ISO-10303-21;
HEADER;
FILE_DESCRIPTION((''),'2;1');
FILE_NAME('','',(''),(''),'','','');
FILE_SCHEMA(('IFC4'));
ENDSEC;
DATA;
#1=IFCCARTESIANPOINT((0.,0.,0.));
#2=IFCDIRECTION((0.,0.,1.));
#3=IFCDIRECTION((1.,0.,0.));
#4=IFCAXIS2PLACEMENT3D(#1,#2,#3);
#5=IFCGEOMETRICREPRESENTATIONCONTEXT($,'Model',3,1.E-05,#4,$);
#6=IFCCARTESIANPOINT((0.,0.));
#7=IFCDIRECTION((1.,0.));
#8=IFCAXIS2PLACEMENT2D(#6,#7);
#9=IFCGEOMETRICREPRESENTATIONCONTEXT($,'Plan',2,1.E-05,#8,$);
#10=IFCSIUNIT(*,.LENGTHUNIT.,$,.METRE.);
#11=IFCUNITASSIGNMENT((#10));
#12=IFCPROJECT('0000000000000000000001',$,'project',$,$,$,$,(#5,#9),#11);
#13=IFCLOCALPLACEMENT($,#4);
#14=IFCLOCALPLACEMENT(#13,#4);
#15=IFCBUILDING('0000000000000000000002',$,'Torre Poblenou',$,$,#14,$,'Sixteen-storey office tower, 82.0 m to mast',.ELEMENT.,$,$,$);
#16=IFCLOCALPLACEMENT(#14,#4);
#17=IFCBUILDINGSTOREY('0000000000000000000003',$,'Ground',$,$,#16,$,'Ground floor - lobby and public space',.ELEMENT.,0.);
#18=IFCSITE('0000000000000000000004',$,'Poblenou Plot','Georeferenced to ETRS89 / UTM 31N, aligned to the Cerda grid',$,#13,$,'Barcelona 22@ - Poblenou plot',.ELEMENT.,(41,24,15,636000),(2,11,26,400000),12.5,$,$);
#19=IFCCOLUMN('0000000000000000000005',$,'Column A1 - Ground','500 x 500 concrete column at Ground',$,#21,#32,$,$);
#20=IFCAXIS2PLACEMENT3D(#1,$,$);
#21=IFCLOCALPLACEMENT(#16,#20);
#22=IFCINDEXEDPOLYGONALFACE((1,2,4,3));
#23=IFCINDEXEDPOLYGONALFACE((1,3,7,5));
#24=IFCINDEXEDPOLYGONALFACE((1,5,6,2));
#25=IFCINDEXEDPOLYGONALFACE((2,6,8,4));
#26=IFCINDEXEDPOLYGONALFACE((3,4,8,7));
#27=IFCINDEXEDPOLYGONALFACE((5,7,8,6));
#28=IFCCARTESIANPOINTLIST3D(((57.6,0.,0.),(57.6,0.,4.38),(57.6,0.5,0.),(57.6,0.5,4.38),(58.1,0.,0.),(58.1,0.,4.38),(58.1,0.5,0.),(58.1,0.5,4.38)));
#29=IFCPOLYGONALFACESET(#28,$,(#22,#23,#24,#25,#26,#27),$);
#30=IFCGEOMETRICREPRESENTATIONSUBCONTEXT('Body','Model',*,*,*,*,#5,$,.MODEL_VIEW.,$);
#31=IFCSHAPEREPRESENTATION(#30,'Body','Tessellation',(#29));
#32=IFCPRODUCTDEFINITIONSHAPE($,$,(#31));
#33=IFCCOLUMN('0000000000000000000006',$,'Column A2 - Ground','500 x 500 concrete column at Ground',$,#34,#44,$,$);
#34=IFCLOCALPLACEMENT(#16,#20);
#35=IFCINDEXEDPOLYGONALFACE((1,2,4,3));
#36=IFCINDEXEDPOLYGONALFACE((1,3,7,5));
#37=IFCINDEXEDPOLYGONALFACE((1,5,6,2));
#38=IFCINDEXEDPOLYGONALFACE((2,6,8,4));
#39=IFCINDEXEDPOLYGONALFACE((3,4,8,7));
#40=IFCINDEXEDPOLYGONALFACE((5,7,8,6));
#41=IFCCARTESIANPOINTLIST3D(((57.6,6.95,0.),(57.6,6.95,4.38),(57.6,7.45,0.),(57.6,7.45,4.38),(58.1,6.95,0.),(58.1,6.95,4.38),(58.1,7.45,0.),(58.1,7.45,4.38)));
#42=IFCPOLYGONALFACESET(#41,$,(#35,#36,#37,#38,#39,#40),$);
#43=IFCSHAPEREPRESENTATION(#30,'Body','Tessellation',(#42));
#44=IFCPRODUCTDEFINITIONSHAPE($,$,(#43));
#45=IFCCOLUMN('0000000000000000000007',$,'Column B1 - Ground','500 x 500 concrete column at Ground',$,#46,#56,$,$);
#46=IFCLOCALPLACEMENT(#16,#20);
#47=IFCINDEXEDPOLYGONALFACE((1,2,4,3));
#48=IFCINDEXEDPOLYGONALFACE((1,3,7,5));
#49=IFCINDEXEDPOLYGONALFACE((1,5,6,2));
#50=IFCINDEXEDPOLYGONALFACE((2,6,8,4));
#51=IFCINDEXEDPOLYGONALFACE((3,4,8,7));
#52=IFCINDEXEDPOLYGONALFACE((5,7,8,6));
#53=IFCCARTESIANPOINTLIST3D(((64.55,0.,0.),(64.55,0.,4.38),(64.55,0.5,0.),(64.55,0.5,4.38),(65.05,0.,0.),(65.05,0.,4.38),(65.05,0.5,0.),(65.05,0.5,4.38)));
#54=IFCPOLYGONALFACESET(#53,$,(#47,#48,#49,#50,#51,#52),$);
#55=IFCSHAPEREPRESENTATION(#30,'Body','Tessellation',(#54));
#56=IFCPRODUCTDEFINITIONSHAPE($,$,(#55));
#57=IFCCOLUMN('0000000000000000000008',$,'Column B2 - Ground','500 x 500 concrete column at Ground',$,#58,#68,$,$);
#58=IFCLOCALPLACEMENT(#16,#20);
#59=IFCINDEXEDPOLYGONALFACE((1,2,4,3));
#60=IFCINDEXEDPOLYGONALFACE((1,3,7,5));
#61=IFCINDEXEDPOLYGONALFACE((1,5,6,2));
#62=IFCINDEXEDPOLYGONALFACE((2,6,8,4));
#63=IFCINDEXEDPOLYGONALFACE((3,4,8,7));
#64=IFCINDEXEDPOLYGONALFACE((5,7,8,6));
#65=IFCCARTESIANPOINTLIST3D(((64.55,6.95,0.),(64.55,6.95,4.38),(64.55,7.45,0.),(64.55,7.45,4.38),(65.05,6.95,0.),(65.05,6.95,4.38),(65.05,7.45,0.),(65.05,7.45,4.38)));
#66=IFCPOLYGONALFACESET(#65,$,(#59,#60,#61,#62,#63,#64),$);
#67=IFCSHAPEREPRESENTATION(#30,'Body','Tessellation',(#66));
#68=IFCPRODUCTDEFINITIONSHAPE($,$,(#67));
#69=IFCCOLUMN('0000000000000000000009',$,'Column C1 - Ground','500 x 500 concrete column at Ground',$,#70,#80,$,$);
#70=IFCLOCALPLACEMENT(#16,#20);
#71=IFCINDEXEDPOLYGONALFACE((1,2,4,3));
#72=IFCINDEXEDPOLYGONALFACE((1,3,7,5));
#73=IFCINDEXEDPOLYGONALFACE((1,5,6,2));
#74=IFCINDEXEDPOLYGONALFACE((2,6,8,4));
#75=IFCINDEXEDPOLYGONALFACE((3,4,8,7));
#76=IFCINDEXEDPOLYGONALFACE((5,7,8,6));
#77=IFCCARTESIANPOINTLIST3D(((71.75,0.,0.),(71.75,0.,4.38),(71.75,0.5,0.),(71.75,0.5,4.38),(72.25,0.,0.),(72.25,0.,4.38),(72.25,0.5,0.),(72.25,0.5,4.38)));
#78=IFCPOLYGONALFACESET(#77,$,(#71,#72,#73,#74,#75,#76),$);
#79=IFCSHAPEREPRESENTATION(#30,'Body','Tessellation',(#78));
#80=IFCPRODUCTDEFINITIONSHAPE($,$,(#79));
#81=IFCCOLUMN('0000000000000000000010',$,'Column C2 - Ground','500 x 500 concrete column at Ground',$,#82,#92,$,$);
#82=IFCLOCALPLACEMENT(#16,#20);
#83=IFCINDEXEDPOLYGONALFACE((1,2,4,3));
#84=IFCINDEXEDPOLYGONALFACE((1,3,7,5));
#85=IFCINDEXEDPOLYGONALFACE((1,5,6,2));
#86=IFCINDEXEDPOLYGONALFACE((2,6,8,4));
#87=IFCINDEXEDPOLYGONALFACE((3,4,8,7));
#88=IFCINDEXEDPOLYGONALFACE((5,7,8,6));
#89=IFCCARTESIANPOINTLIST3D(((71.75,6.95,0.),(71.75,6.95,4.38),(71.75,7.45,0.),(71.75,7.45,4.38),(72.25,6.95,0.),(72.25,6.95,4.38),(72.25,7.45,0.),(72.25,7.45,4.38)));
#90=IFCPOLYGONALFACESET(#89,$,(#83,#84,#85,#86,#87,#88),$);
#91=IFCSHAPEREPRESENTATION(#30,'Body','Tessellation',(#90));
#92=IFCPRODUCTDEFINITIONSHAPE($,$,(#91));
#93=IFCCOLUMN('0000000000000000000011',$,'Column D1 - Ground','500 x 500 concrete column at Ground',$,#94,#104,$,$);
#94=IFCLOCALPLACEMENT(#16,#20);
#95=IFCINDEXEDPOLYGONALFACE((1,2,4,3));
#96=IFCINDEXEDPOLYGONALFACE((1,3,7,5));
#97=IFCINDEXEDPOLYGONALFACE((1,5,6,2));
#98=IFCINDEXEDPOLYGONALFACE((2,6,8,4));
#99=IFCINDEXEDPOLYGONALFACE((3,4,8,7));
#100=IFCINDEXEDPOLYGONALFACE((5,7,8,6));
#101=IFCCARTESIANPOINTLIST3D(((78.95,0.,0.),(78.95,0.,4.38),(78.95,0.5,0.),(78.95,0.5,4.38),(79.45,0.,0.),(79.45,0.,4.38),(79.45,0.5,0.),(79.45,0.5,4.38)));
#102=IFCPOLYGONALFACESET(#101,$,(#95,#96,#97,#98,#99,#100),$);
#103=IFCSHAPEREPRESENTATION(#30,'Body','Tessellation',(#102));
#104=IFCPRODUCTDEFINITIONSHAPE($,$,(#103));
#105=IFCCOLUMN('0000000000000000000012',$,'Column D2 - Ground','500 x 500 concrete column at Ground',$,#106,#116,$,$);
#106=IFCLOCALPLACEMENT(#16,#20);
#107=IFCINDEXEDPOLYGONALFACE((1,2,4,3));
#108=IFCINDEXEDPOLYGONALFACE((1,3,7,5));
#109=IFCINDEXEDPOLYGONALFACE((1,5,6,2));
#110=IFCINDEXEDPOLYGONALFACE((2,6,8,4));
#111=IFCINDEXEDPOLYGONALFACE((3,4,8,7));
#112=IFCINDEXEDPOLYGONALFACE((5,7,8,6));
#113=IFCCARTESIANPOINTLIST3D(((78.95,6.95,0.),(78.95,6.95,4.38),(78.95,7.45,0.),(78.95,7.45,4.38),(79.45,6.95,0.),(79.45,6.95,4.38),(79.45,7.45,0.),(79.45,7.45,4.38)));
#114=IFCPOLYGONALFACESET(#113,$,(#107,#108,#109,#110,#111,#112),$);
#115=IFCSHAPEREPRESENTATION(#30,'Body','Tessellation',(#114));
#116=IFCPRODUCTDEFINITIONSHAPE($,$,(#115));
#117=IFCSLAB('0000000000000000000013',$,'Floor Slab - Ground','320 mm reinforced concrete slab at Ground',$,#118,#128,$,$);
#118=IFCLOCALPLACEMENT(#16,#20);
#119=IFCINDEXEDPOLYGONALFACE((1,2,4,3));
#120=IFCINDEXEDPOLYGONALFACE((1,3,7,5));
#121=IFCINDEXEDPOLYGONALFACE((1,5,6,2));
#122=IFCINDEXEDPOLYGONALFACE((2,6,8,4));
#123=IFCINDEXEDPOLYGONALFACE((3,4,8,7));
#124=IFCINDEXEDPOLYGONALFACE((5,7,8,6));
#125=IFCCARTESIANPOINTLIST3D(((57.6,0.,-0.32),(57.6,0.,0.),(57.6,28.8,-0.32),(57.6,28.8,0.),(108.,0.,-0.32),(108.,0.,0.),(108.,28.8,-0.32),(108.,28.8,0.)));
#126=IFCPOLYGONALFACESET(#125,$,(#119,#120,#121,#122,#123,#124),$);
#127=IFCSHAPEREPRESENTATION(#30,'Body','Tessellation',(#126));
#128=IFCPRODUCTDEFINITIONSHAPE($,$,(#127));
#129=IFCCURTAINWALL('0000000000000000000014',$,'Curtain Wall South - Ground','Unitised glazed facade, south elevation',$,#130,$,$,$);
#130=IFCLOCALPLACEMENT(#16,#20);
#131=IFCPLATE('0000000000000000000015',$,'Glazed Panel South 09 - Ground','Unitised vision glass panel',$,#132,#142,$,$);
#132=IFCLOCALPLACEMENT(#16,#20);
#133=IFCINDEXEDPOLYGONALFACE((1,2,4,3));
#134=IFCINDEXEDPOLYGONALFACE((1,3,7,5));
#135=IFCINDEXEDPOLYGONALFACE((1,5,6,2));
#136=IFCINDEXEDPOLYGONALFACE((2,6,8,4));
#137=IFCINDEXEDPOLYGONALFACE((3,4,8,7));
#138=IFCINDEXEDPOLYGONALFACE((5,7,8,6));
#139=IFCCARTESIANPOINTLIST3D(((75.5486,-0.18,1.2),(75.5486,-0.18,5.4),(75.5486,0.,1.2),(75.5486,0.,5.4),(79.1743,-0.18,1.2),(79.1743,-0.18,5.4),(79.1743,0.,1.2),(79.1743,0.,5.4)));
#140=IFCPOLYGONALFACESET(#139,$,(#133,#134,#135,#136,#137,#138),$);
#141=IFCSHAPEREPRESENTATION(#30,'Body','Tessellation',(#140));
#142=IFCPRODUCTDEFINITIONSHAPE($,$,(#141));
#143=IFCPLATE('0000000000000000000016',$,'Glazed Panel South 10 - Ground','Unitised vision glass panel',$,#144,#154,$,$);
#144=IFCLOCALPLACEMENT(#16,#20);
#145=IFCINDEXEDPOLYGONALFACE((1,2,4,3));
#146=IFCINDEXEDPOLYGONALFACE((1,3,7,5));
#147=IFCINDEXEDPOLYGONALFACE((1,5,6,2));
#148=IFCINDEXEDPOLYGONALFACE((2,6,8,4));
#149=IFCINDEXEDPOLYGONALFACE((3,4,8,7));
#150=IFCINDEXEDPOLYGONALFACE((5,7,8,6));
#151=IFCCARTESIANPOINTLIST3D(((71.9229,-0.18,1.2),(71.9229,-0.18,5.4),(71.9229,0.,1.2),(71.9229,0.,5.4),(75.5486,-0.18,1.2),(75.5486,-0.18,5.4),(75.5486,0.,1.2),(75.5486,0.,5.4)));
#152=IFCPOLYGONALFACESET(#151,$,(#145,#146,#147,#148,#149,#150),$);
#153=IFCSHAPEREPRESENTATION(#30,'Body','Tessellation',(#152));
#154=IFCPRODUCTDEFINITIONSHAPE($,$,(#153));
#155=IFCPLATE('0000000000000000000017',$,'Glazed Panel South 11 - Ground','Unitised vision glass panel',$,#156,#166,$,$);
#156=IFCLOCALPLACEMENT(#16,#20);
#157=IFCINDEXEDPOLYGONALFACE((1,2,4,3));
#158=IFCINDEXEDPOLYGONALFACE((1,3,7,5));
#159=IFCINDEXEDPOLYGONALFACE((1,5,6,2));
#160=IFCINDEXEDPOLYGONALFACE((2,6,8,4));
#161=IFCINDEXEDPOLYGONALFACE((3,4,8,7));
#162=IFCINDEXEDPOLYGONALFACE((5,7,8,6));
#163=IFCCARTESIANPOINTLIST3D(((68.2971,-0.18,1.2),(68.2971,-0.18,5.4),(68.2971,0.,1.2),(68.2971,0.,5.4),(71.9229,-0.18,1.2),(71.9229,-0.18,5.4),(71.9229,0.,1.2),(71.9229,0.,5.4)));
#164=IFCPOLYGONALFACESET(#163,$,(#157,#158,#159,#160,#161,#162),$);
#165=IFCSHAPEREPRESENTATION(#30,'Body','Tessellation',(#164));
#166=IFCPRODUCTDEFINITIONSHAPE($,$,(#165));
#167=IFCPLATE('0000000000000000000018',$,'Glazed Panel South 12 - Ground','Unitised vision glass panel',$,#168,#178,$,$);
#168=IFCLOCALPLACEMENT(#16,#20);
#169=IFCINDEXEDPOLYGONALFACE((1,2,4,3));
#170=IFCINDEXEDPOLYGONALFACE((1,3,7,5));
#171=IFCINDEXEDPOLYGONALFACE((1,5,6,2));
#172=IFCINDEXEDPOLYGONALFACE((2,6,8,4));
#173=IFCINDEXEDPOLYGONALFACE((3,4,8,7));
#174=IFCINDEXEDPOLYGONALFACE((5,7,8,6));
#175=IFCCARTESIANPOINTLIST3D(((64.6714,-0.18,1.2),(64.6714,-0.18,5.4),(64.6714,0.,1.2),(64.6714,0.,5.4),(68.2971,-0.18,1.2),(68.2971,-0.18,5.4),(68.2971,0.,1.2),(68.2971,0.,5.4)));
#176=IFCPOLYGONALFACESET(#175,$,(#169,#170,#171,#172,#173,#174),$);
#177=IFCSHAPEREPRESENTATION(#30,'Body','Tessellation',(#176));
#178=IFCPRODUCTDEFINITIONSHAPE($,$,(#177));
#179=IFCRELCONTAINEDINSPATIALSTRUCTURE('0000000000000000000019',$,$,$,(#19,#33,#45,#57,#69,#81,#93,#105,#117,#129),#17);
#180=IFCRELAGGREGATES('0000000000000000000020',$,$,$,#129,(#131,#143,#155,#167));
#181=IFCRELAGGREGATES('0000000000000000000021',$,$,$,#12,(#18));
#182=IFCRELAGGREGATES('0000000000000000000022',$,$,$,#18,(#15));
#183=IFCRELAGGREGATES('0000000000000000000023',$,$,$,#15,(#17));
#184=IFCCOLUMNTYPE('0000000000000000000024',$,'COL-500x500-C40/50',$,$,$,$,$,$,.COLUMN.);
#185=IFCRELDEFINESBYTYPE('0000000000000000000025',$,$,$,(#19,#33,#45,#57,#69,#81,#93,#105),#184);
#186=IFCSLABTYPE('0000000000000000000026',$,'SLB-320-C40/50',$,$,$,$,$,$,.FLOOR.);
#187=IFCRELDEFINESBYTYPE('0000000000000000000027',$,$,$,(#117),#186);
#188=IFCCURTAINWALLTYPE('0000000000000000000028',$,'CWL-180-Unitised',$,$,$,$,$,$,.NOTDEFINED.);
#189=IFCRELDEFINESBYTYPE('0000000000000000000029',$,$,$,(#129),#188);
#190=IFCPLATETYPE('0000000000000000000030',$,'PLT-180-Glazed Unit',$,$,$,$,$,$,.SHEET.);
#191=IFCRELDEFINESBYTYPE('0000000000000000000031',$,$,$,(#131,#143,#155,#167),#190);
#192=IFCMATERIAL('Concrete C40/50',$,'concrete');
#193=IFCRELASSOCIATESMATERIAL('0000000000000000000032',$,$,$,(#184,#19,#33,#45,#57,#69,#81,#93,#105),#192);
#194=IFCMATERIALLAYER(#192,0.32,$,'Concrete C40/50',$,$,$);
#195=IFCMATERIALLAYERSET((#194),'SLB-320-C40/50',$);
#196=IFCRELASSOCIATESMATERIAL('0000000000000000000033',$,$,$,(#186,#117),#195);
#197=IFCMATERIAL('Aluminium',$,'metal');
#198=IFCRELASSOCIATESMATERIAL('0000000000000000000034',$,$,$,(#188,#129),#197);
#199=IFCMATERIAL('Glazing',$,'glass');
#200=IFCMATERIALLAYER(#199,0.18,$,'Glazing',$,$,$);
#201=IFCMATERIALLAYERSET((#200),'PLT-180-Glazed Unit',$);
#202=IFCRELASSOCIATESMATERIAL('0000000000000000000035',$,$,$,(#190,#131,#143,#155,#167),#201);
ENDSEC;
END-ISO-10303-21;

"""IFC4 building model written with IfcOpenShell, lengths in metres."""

from ifc_helpers import new_model, si_unit, frame, origin_with_axes, origin_2d_with_axis, place, context, subcontext, project, spatial, line, indexed_curve, rectangle, outline, extrude, material, layer, layer_set, layer_usage, material_profile, profile_set, profile_usage, type_object, element, aggregate, save


model = new_model("IFC4")

# Units and contexts
model_context = context("Model", 3, precision=1e-05, world=origin_with_axes())
plan_context = context("Plan", 2, precision=1e-05, world=origin_2d_with_axis())
body_context = subcontext(model_context, "Body", "Model", "MODEL_VIEW")
ifc_project = project(units=[si_unit("LENGTHUNIT", "METRE")], contexts=[model_context, plan_context])

# Site, building, storey
site_placement = place(None, origin_with_axes())
site = spatial("IfcSite", under=ifc_project, at=site_placement, Name="Poblenou Plot", Description="Georeferenced to ETRS89 / UTM 31N, aligned to the Cerda grid", LongName="Barcelona 22@ - Poblenou plot", CompositionType="ELEMENT", RefLatitude=(41, 24, 15, 636000), RefLongitude=(2, 11, 26, 400000), RefElevation=12.5)
building_placement = place(site_placement, origin_with_axes())
building = spatial("IfcBuilding", under=site, at=building_placement, Name="Torre Poblenou", LongName="Sixteen-storey office tower, 82.0 m to mast", CompositionType="ELEMENT")
storey_placement = place(building_placement, origin_with_axes())
storey = spatial("IfcBuildingStorey", under=building, at=storey_placement, Name="Ground", LongName="Ground floor - lobby and public space", CompositionType="ELEMENT", Elevation=0.0)

# Columns
ifc_material_1 = material(Name="Concrete C40/50", Category="concrete")
ifc_material_profile = material_profile(ifc_material_1, rectangle(XDim=0.5, YDim=0.5))
ifc_profile_set = profile_set([ifc_material_profile], Name="COL-500x500-C40/50")
ifc_profile_usage_1 = profile_usage(ifc_profile_set)
column_type = type_object("IfcColumnType", Name="COL-500x500-C40/50", PredefinedType="COLUMN", material=ifc_profile_set)
column_1_placement = place(storey_placement, frame((57.6, 0.0, 0.0), z_axis=(0.0, 0.0, 1.0), x_axis=(1.0, 0.0, 0.0)))
element("IfcColumn", 1, at=column_1_placement, inside=storey, type_object=column_type, material=ifc_profile_usage_1, Name="Column A1 - Ground", Description="500 x 500 concrete column at Ground", context=body_context, shape_type="SweptSolid", body=[
    extrude(outline(indexed_curve([(0.0, 0.0), (0.5, 0.0), (0.5, 0.5), (0.0, 0.5)], segments=[line(1, 2, 3, 4, 1)])), origin_with_axes(), (0.0, 0.0, 1.0), 4.38),
])
ifc_profile_usage_2 = profile_usage(ifc_profile_set)
column_2_placement = place(storey_placement, frame((57.6, 6.95, 0.0), z_axis=(0.0, 0.0, 1.0), x_axis=(1.0, 0.0, 0.0)))
element("IfcColumn", 2, at=column_2_placement, inside=storey, type_object=column_type, material=ifc_profile_usage_2, Name="Column A2 - Ground", Description="500 x 500 concrete column at Ground", context=body_context, shape_type="SweptSolid", body=[
    extrude(outline(indexed_curve([(0.0, 0.0), (0.5, 0.0), (0.5, 0.5), (0.0, 0.5)], segments=[line(1, 2, 3, 4, 1)])), origin_with_axes(), (0.0, 0.0, 1.0), 4.38),
])
ifc_profile_usage_3 = profile_usage(ifc_profile_set)
column_3_placement = place(storey_placement, frame((64.55, 0.0, 0.0), z_axis=(0.0, 0.0, 1.0), x_axis=(1.0, 0.0, 0.0)))
element("IfcColumn", 3, at=column_3_placement, inside=storey, type_object=column_type, material=ifc_profile_usage_3, Name="Column B1 - Ground", Description="500 x 500 concrete column at Ground", context=body_context, shape_type="SweptSolid", body=[
    extrude(outline(indexed_curve([(0.0, 0.0), (0.5, 0.0), (0.5, 0.5), (0.0, 0.5)], segments=[line(1, 2, 3, 4, 1)])), origin_with_axes(), (0.0, 0.0, 1.0), 4.38),
])
ifc_profile_usage_4 = profile_usage(ifc_profile_set)
column_4_placement = place(storey_placement, frame((64.55, 6.95, 0.0), z_axis=(0.0, 0.0, 1.0), x_axis=(1.0, 0.0, 0.0)))
element("IfcColumn", 4, at=column_4_placement, inside=storey, type_object=column_type, material=ifc_profile_usage_4, Name="Column B2 - Ground", Description="500 x 500 concrete column at Ground", context=body_context, shape_type="SweptSolid", body=[
    extrude(outline(indexed_curve([(0.0, 0.0), (0.5, 0.0), (0.5, 0.5), (0.0, 0.5)], segments=[line(1, 2, 3, 4, 1)])), origin_with_axes(), (0.0, 0.0, 1.0), 4.38),
])
ifc_profile_usage_5 = profile_usage(ifc_profile_set)
column_5_placement = place(storey_placement, frame((71.75, 0.0, 0.0), z_axis=(0.0, 0.0, 1.0), x_axis=(1.0, 0.0, 0.0)))
element("IfcColumn", 5, at=column_5_placement, inside=storey, type_object=column_type, material=ifc_profile_usage_5, Name="Column C1 - Ground", Description="500 x 500 concrete column at Ground", context=body_context, shape_type="SweptSolid", body=[
    extrude(outline(indexed_curve([(0.0, 0.0), (0.5, 0.0), (0.5, 0.5), (0.0, 0.5)], segments=[line(1, 2, 3, 4, 1)])), origin_with_axes(), (0.0, 0.0, 1.0), 4.38),
])
ifc_profile_usage_6 = profile_usage(ifc_profile_set)
column_6_placement = place(storey_placement, frame((71.75, 6.95, 0.0), z_axis=(0.0, 0.0, 1.0), x_axis=(1.0, 0.0, 0.0)))
element("IfcColumn", 6, at=column_6_placement, inside=storey, type_object=column_type, material=ifc_profile_usage_6, Name="Column C2 - Ground", Description="500 x 500 concrete column at Ground", context=body_context, shape_type="SweptSolid", body=[
    extrude(outline(indexed_curve([(0.0, 0.0), (0.5, 0.0), (0.5, 0.5), (0.0, 0.5)], segments=[line(1, 2, 3, 4, 1)])), origin_with_axes(), (0.0, 0.0, 1.0), 4.38),
])
ifc_profile_usage_7 = profile_usage(ifc_profile_set)
column_7_placement = place(storey_placement, frame((78.95, 0.0, 0.0), z_axis=(0.0, 0.0, 1.0), x_axis=(1.0, 0.0, 0.0)))
element("IfcColumn", 7, at=column_7_placement, inside=storey, type_object=column_type, material=ifc_profile_usage_7, Name="Column D1 - Ground", Description="500 x 500 concrete column at Ground", context=body_context, shape_type="SweptSolid", body=[
    extrude(outline(indexed_curve([(0.0, 0.0), (0.5, 0.0), (0.5, 0.5), (0.0, 0.5)], segments=[line(1, 2, 3, 4, 1)])), origin_with_axes(), (0.0, 0.0, 1.0), 4.38),
])
ifc_profile_usage_8 = profile_usage(ifc_profile_set)
column_8_placement = place(storey_placement, frame((78.95, 6.95, 0.0), z_axis=(0.0, 0.0, 1.0), x_axis=(1.0, 0.0, 0.0)))
element("IfcColumn", 8, at=column_8_placement, inside=storey, type_object=column_type, material=ifc_profile_usage_8, Name="Column D2 - Ground", Description="500 x 500 concrete column at Ground", context=body_context, shape_type="SweptSolid", body=[
    extrude(outline(indexed_curve([(0.0, 0.0), (0.5, 0.0), (0.5, 0.5), (0.0, 0.5)], segments=[line(1, 2, 3, 4, 1)])), origin_with_axes(), (0.0, 0.0, 1.0), 4.38),
])

# Slab
ifc_layer_1 = layer(ifc_material_1, 0.32, Name="Concrete C40/50")
ifc_layer_set_1 = layer_set([ifc_layer_1], Name="SLB-320-C40/50")
ifc_layer_usage_1 = layer_usage(ifc_layer_set_1, "AXIS3", "POSITIVE", 0.0)
slab_type_1 = type_object("IfcSlabType", Name="SLB-320-C40/50", PredefinedType="FLOOR", material=ifc_layer_set_1)
slab_1_placement = place(storey_placement, frame((57.6, 0.0, -0.32), z_axis=(0.0, 0.0, 1.0), x_axis=(1.0, 0.0, 0.0)))
element("IfcSlab", 9, at=slab_1_placement, inside=storey, type_object=slab_type_1, material=ifc_layer_usage_1, Name="Floor Slab - Ground", Description="320 mm reinforced concrete slab at Ground", context=body_context, shape_type="SweptSolid", body=[
    extrude(outline(indexed_curve([(0.0, 0.0), (50.4, 0.0), (50.4, 28.8), (0.0, 28.8)], segments=[line(1, 2, 3, 4, 1)])), origin_with_axes(), (0.0, 0.0, 1.0), 0.32),
])

# Curtain wall, plates
ifc_material_2 = material(Name="Aluminium", Category="metal")
curtain_wall_type = type_object("IfcCurtainWallType", Name="CWL-180-Unitised", PredefinedType="NOTDEFINED", material=ifc_material_2)
curtain_wall_1_placement = place(storey_placement, frame((108.18, 0.0, 0.0), z_axis=(0.0, 0.0, 1.0), x_axis=(-1.0, 0.0, 0.0)))
curtain_wall_1 = element("IfcCurtainWall", 10, at=curtain_wall_1_placement, inside=storey, type_object=curtain_wall_type, material=ifc_material_2, Name="Curtain Wall South - Ground", Description="Unitised glazed facade, south elevation")
ifc_material_3 = material(Name="Glazing", Category="glass")
ifc_layer_2 = layer(ifc_material_3, 0.18, Name="Glazing")
ifc_layer_set_2 = layer_set([ifc_layer_2], Name="PLT-180-Glazed Unit")
ifc_layer_usage_2 = layer_usage(ifc_layer_set_2, "AXIS2", "POSITIVE", 0.0)
plate_type_1 = type_object("IfcPlateType", Name="PLT-180-Glazed Unit", PredefinedType="SHEET", material=ifc_layer_set_2)
plate_1_placement = place(curtain_wall_1_placement, frame((29.0057, 0.0, 1.2), z_axis=(0.0, 0.0, 1.0), x_axis=(1.0, 0.0, 0.0)))
plate_1 = element("IfcPlate", 11, at=plate_1_placement, type_object=plate_type_1, material=ifc_layer_usage_2, Name="Glazed Panel South 09 - Ground", Description="Unitised vision glass panel", context=body_context, shape_type="SweptSolid", body=[
    extrude(outline(indexed_curve([(0.0, 0.0), (3.6257, 0.0), (3.6257, 0.18), (0.0, 0.18)], segments=[line(1, 2, 3, 4, 1)])), origin_with_axes(), (0.0, 0.0, 1.0), 4.2),
])
ifc_layer_usage_3 = layer_usage(ifc_layer_set_2, "AXIS2", "POSITIVE", 0.0)
plate_2_placement = place(curtain_wall_1_placement, frame((32.6314, 0.0, 1.2), z_axis=(0.0, 0.0, 1.0), x_axis=(1.0, 0.0, 0.0)))
plate_2 = element("IfcPlate", 12, at=plate_2_placement, type_object=plate_type_1, material=ifc_layer_usage_3, Name="Glazed Panel South 10 - Ground", Description="Unitised vision glass panel", context=body_context, shape_type="SweptSolid", body=[
    extrude(outline(indexed_curve([(0.0, 0.0), (3.6257, 0.0), (3.6257, 0.18), (0.0, 0.18)], segments=[line(1, 2, 3, 4, 1)])), origin_with_axes(), (0.0, 0.0, 1.0), 4.2),
])
ifc_layer_usage_4 = layer_usage(ifc_layer_set_2, "AXIS2", "POSITIVE", 0.0)
plate_3_placement = place(curtain_wall_1_placement, frame((36.2571, 0.0, 1.2), z_axis=(0.0, 0.0, 1.0), x_axis=(1.0, 0.0, 0.0)))
plate_3 = element("IfcPlate", 13, at=plate_3_placement, type_object=plate_type_1, material=ifc_layer_usage_4, Name="Glazed Panel South 11 - Ground", Description="Unitised vision glass panel", context=body_context, shape_type="SweptSolid", body=[
    extrude(outline(indexed_curve([(0.0, 0.0), (3.6257, 0.0), (3.6257, 0.18), (0.0, 0.18)], segments=[line(1, 2, 3, 4, 1)])), origin_with_axes(), (0.0, 0.0, 1.0), 4.2),
])
ifc_layer_usage_5 = layer_usage(ifc_layer_set_2, "AXIS2", "POSITIVE", 0.0)
plate_4_placement = place(curtain_wall_1_placement, frame((39.8829, 0.0, 1.2), z_axis=(0.0, 0.0, 1.0), x_axis=(1.0, 0.0, 0.0)))
plate_4 = element("IfcPlate", 14, at=plate_4_placement, type_object=plate_type_1, material=ifc_layer_usage_5, Name="Glazed Panel South 12 - Ground", Description="Unitised vision glass panel", context=body_context, shape_type="SweptSolid", body=[
    extrude(outline(indexed_curve([(0.0, 0.0), (3.6257, 0.0), (3.6257, 0.18), (0.0, 0.18)], segments=[line(1, 2, 3, 4, 1)])), origin_with_axes(), (0.0, 0.0, 1.0), 4.2),
])

aggregate(curtain_wall_1, [plate_1, plate_2, plate_3, plate_4])

save(model, "model.ifc")
